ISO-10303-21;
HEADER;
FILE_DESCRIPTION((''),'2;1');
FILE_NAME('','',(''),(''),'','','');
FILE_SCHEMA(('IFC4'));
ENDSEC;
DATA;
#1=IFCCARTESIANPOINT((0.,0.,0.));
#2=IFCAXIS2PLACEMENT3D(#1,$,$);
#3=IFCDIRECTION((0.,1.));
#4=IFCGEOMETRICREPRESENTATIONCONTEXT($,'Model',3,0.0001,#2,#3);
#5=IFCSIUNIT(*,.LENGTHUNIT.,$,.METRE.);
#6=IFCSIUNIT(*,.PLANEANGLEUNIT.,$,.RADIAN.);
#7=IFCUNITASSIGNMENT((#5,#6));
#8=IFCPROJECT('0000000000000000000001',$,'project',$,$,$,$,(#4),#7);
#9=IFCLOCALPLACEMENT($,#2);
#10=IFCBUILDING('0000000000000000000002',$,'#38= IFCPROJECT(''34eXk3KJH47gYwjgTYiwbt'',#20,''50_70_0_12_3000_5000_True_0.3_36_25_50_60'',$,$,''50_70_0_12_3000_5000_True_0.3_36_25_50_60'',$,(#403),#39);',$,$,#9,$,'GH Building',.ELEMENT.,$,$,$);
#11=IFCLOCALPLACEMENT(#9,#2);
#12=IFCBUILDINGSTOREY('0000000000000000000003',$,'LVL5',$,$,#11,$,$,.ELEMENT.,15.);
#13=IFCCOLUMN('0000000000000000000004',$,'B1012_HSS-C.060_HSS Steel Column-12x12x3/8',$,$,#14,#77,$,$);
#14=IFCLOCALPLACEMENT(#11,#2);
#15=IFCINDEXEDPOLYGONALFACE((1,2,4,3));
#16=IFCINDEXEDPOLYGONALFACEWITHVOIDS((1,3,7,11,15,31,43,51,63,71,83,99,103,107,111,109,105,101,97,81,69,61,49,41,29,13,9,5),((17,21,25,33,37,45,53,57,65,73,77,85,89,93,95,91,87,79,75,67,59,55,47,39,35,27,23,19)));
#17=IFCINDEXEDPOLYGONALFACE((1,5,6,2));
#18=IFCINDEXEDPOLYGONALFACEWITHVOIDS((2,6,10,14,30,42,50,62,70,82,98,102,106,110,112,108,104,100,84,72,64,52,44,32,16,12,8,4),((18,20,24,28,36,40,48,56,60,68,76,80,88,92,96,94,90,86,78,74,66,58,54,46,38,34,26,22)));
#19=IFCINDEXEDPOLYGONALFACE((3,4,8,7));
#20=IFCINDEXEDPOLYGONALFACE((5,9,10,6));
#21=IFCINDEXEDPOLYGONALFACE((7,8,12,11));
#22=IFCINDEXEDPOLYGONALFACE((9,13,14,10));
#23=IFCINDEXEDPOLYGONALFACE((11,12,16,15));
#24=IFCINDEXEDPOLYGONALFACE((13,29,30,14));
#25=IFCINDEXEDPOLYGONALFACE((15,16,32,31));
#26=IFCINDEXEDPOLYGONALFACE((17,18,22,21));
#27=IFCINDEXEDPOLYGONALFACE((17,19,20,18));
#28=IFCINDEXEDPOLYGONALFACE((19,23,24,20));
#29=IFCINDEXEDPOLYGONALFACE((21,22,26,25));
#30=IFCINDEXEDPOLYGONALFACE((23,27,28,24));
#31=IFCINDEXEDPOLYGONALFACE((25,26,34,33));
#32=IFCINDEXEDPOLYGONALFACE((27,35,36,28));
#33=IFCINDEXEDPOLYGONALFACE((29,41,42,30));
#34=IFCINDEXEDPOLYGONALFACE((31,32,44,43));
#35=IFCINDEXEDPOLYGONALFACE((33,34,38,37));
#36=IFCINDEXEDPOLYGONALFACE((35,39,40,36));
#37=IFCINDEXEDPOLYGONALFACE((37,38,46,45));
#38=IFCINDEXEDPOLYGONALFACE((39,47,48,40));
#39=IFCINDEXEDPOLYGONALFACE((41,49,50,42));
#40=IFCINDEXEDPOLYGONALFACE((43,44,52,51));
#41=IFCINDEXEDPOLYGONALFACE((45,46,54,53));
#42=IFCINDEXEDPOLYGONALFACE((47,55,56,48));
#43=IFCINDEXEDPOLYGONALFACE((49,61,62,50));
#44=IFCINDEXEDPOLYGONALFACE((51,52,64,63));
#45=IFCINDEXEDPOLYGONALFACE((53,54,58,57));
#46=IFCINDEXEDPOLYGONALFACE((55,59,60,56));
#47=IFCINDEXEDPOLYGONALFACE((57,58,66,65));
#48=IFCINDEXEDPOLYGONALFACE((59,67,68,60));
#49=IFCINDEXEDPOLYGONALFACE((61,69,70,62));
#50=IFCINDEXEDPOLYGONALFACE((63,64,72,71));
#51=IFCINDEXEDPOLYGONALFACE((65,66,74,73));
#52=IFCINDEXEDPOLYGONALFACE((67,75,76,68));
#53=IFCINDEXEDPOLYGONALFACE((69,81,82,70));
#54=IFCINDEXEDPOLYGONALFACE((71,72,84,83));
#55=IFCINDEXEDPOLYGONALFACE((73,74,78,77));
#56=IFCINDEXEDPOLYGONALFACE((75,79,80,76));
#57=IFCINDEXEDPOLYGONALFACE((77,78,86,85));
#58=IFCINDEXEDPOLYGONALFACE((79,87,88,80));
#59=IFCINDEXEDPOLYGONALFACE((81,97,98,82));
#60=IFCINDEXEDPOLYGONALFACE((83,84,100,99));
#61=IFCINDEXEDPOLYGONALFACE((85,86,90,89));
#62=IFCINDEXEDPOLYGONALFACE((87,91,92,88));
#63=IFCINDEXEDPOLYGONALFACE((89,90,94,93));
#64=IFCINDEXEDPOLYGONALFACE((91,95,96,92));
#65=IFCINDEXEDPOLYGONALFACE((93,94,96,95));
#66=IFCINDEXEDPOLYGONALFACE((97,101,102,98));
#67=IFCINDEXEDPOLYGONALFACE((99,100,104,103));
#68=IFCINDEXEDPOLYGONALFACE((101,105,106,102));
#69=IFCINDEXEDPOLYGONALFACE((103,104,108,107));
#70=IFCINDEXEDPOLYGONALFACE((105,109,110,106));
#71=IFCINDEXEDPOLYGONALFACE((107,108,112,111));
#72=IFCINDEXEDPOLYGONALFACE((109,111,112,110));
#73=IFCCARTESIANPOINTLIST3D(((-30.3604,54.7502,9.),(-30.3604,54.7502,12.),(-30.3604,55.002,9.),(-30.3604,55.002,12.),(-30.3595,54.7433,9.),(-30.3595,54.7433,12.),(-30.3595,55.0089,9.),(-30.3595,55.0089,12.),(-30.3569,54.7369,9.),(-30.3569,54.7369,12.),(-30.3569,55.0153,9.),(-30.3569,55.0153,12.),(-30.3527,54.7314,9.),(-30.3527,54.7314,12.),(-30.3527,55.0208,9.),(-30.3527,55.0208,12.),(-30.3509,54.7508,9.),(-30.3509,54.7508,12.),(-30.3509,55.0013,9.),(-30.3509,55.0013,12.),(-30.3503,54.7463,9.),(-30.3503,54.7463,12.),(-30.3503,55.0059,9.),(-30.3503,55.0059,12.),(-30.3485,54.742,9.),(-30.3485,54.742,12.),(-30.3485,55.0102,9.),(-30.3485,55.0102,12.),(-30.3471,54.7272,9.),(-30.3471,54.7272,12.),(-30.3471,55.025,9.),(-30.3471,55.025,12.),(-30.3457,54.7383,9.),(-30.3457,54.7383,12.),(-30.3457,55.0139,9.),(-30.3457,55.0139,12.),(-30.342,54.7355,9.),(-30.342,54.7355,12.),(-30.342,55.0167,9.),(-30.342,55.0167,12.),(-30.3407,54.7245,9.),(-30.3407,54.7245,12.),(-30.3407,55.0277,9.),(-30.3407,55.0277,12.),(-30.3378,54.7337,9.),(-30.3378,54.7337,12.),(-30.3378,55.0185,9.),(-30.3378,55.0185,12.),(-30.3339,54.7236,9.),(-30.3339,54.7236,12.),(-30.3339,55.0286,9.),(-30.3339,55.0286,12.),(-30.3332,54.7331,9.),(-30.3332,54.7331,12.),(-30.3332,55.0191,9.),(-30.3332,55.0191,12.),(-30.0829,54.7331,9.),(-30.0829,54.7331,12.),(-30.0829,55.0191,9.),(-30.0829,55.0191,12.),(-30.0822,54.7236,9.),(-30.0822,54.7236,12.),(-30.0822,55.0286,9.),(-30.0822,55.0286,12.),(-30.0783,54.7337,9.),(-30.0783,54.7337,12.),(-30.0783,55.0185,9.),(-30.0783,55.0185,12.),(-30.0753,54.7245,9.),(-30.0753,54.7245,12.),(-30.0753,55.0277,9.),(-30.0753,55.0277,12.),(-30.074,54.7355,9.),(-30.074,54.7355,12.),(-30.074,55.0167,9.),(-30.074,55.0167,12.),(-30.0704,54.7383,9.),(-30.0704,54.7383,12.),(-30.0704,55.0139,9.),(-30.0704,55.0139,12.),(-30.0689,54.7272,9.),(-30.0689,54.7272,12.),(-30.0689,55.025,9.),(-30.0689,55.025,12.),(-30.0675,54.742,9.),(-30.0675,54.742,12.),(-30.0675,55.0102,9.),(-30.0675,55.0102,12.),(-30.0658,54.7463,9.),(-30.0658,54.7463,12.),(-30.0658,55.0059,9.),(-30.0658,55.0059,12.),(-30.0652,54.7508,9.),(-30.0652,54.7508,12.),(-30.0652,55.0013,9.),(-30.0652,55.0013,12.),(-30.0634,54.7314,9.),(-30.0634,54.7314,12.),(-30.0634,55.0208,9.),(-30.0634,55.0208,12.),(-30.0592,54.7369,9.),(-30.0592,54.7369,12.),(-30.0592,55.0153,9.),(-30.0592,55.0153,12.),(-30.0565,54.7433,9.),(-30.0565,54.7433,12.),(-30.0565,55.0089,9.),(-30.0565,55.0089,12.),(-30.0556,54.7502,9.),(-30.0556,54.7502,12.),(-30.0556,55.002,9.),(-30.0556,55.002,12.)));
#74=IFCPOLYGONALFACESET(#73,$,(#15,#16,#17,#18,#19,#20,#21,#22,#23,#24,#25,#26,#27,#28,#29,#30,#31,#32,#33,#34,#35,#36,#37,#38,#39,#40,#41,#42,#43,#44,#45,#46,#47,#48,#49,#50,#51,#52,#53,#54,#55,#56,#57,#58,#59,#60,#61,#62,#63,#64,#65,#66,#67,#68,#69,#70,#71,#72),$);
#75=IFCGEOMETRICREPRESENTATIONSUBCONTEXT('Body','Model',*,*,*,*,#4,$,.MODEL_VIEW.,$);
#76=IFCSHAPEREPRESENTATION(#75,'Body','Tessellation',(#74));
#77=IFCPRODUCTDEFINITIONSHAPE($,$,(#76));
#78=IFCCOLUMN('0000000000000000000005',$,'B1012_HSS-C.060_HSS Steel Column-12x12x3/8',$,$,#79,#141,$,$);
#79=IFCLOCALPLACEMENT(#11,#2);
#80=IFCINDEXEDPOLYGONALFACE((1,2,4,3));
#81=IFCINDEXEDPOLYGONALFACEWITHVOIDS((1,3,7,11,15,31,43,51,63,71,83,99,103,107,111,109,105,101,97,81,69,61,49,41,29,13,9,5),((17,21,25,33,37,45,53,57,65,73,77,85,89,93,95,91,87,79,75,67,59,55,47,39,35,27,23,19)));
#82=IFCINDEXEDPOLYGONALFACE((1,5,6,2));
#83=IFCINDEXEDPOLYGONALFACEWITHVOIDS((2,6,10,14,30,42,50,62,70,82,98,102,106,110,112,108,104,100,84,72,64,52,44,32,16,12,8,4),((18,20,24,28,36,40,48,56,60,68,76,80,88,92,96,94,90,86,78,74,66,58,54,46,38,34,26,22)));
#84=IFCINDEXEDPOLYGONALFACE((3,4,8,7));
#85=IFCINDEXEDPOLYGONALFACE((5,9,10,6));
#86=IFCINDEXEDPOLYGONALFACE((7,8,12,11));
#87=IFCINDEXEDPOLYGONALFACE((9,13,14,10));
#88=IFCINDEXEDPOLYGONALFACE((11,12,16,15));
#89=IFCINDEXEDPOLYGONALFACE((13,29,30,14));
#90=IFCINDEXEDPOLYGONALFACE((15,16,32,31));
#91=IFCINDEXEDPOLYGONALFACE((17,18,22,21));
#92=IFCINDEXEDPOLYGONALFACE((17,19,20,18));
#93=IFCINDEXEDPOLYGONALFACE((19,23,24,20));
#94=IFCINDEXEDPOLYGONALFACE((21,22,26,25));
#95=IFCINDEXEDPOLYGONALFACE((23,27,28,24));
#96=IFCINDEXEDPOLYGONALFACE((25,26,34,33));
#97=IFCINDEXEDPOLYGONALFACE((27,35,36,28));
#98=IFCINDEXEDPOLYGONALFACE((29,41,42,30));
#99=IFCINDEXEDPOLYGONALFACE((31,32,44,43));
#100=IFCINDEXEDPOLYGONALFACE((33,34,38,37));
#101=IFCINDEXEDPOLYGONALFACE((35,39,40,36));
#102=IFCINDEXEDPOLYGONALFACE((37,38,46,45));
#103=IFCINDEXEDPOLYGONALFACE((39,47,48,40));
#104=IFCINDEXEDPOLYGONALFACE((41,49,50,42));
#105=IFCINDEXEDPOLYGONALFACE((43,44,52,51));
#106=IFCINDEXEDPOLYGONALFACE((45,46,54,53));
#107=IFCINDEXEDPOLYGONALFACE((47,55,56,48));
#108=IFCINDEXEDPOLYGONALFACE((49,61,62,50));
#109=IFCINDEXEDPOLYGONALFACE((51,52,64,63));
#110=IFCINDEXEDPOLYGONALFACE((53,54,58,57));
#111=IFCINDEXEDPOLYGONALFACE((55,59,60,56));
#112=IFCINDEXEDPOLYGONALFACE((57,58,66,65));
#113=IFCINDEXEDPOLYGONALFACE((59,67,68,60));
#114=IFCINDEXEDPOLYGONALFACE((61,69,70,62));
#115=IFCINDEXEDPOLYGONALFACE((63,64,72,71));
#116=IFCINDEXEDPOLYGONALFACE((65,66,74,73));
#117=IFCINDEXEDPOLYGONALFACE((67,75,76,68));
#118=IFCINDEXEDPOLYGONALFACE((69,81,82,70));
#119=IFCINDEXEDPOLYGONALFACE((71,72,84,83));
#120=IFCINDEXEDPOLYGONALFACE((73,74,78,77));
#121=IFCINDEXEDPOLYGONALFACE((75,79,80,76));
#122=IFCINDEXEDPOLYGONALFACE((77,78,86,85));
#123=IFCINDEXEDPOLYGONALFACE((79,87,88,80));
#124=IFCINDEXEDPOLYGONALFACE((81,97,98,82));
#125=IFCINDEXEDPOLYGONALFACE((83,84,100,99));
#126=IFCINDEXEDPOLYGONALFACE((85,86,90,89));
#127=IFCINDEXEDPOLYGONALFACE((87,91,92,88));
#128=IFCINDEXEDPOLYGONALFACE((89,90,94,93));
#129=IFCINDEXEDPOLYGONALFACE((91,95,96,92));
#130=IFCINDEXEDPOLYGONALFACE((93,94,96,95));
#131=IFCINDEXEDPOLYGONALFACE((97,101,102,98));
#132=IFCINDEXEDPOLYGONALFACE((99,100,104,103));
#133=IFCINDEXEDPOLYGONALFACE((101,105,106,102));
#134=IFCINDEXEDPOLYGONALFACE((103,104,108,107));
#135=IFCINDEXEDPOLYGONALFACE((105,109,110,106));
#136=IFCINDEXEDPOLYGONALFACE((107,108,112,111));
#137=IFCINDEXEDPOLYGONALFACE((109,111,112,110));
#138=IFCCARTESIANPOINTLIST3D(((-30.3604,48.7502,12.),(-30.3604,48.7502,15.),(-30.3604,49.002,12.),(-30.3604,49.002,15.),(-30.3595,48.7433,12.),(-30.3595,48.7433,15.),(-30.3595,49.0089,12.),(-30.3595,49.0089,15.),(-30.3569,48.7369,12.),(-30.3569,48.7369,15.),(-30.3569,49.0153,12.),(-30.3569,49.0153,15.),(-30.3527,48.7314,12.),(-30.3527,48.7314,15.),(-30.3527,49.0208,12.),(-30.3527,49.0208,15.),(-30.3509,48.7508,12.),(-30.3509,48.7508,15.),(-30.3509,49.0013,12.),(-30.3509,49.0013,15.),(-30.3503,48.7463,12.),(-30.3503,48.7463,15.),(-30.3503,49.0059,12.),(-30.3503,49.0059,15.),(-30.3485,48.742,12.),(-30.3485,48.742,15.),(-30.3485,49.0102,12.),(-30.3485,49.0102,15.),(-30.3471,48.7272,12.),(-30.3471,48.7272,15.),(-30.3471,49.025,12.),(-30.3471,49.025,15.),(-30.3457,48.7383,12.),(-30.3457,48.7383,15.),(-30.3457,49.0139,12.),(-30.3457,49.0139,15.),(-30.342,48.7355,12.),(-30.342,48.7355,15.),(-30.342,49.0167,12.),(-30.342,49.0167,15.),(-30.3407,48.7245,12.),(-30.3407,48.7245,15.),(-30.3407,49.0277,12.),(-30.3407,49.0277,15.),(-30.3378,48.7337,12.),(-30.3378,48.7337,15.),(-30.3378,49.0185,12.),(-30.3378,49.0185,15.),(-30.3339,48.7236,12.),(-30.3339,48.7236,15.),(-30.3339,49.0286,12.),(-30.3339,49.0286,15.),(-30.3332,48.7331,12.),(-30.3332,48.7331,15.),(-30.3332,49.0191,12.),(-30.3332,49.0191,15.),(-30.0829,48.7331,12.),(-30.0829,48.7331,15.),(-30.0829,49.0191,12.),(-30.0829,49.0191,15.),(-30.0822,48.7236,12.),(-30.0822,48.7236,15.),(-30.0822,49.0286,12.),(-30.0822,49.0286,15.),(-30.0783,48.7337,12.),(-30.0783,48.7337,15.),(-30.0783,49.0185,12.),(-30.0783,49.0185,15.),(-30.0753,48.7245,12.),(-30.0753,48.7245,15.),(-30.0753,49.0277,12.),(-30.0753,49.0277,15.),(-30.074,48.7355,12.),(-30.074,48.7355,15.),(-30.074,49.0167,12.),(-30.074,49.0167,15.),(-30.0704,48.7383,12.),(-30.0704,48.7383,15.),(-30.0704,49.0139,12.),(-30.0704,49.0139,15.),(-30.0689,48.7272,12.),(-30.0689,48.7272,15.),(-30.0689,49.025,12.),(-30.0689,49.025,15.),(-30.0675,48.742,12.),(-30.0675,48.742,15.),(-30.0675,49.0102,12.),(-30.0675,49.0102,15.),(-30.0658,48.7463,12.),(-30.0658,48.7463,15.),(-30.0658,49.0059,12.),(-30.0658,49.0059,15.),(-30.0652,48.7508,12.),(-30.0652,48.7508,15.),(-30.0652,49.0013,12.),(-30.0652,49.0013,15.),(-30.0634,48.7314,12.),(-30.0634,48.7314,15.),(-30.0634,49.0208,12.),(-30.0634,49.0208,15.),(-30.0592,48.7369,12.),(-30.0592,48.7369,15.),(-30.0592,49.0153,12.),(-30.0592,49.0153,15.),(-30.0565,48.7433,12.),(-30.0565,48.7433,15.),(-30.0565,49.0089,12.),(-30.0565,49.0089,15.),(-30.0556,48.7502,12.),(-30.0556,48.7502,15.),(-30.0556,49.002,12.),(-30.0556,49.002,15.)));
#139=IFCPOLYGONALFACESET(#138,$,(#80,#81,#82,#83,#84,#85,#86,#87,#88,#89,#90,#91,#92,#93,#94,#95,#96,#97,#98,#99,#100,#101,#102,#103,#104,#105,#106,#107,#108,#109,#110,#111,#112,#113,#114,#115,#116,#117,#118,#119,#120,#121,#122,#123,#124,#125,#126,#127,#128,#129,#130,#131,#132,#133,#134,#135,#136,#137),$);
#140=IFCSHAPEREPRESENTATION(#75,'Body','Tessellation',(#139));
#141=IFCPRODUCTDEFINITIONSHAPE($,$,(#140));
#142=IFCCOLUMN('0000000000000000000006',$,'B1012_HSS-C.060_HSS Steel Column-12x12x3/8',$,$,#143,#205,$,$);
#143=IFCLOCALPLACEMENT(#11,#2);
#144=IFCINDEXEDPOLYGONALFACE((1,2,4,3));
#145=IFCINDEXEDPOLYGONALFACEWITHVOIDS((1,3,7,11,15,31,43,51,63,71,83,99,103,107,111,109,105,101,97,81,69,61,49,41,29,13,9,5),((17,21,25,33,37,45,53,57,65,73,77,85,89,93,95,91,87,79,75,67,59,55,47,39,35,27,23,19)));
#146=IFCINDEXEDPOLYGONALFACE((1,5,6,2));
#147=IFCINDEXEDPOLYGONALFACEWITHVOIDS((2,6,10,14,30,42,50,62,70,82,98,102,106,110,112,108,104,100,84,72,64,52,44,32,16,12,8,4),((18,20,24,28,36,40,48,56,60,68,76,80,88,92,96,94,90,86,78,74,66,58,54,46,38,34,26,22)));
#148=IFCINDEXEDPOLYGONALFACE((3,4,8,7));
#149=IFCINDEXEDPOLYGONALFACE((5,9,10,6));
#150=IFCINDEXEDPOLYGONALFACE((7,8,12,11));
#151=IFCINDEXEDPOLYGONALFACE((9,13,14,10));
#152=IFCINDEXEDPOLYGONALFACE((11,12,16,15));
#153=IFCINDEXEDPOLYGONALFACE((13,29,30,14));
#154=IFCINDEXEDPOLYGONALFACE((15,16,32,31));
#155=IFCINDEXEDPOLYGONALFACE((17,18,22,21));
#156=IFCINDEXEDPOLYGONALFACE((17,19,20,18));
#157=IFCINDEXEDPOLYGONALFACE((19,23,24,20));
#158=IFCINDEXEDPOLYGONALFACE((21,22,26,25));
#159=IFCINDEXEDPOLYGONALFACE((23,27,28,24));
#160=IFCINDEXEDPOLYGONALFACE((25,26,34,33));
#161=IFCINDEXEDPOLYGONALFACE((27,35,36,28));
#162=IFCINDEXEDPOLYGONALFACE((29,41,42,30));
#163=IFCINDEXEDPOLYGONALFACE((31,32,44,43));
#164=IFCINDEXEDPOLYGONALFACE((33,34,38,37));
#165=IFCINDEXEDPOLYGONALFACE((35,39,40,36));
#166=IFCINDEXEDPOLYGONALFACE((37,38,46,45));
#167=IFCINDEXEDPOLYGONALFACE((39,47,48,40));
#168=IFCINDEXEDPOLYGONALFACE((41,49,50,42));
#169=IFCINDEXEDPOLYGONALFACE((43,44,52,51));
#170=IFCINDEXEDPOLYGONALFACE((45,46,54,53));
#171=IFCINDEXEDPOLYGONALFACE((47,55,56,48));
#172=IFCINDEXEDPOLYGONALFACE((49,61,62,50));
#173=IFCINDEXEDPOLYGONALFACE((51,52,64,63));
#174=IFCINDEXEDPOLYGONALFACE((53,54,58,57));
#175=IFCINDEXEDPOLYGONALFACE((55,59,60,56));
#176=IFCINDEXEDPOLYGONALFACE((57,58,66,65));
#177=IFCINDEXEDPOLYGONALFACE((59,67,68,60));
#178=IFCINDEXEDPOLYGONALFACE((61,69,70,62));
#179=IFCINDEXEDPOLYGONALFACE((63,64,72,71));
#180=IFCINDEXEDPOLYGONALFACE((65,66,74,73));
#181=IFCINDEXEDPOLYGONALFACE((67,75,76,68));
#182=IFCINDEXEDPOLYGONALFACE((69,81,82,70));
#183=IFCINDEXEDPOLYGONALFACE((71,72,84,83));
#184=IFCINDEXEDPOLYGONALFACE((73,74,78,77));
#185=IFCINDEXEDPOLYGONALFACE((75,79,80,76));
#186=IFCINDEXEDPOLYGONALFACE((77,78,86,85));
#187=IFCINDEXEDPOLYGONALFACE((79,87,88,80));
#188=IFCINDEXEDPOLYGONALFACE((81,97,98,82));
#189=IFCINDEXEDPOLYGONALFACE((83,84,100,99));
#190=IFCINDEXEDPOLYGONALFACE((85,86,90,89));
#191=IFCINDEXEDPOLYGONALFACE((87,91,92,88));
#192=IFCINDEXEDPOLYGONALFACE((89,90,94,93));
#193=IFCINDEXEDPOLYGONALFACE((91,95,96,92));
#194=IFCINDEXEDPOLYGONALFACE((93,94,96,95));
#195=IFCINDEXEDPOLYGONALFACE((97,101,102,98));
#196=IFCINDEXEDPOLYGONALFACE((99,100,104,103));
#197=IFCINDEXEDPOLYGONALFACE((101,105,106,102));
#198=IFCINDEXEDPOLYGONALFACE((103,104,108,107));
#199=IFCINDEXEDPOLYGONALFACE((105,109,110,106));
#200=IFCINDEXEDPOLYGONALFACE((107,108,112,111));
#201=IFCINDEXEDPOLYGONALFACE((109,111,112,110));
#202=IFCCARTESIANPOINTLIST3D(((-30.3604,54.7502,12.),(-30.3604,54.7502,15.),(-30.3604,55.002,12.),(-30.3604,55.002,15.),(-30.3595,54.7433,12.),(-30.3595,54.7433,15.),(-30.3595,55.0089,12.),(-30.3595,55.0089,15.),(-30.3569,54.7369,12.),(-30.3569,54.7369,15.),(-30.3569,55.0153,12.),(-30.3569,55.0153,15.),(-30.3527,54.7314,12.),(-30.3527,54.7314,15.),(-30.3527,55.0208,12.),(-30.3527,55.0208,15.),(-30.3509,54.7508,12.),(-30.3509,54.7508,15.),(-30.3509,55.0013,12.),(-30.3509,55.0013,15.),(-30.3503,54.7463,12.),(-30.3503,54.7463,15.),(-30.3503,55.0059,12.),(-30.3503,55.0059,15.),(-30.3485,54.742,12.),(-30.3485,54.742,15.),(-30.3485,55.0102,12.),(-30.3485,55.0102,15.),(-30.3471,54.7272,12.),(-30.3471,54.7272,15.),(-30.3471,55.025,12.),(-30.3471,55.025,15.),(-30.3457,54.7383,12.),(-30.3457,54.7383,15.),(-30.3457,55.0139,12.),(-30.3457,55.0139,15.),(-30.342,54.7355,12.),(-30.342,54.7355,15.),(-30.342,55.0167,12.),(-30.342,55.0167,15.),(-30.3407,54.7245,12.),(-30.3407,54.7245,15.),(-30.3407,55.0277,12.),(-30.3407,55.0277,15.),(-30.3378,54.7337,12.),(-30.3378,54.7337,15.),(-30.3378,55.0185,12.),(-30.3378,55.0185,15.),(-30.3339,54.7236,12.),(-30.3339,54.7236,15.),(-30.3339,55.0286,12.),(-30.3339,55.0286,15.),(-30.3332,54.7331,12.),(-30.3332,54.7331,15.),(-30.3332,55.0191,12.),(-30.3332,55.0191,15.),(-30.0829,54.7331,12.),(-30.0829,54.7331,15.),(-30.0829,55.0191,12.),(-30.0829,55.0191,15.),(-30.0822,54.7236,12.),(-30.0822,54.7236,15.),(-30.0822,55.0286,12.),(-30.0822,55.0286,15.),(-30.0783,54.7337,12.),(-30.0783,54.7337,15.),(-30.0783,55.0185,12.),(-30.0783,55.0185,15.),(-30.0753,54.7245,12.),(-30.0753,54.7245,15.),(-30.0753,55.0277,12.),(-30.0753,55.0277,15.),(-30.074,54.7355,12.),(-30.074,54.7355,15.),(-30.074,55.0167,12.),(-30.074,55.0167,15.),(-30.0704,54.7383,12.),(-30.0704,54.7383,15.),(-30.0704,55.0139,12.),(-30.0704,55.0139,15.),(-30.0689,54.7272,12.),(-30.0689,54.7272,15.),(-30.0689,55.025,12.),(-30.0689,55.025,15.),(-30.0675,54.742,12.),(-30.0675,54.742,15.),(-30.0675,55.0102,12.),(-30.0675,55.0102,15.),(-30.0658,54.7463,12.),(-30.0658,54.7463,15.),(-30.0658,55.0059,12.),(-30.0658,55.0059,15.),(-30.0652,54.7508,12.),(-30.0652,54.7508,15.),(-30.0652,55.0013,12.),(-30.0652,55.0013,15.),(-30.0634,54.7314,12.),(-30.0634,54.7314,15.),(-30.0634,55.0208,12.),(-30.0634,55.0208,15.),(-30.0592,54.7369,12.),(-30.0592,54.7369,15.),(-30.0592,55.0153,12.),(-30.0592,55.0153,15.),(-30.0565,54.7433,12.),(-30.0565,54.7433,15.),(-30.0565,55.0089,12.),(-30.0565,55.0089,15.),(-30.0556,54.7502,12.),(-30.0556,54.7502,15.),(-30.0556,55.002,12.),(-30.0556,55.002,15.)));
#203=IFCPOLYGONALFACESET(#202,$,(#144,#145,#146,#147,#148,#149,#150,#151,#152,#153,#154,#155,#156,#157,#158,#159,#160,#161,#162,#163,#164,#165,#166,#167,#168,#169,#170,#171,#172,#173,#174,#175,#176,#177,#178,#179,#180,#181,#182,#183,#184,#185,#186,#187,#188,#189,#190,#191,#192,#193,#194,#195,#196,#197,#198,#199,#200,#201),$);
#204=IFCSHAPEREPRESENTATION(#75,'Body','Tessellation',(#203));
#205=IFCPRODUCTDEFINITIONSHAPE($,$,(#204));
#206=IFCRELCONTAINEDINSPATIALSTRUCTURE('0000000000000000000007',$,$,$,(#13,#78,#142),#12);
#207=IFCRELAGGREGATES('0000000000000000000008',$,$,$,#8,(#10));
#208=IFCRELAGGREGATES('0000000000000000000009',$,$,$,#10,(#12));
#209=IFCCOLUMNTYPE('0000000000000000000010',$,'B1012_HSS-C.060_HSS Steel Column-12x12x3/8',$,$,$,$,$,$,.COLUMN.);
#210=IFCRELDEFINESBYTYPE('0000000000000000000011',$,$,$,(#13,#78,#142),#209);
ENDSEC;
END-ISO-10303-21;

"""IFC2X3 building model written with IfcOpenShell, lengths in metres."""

from ifc_helpers import new_model, si_unit, direction, frame, origin, origin_2d, place, context, subcontext, project, spatial, hollow_rectangle, extrude, type_object, element, save


model = new_model("IFC2X3")

# Units and contexts
model_context = context("Model", 3, precision=0.0001, world=origin(), true_north=direction((0.0, 1.0)))
body_context = subcontext(model_context, "Body", "Model", "MODEL_VIEW")
ifc_project = project(units=[si_unit("LENGTHUNIT", "METRE"), si_unit("PLANEANGLEUNIT", "RADIAN")], contexts=[model_context])

# Building, storey
building_placement = place(None, origin())
building = spatial("IfcBuilding", under=ifc_project, at=building_placement, Name="#38= IFCPROJECT('34eXk3KJH47gYwjgTYiwbt',#20,'50_70_0_12_3000_5000_True_0.3_36_25_50_60',$,$,'50_70_0_12_3000_5000_True_0.3_36_25_50_60',$,(#403),#39);", LongName="GH Building", CompositionType="ELEMENT")
storey_placement = place(building_placement, origin())
storey = spatial("IfcBuildingStorey", under=building, at=storey_placement, Name="LVL5", CompositionType="ELEMENT", Elevation=15.0)

# Columns
column_type = type_object("IfcColumnType", Name="B1012_HSS-C.060_HSS Steel Column-12x12x3/8", PredefinedType="COLUMN")
for number, where, z_axis, x_axis, name in (
    (1, (-30.208, 54.8761, 12.0), (0.0, 0.0, -1.0), (-1.0, 0.0, 0.0), "B1012_HSS-C.060_HSS Steel Column-12x12x3/8"),
    (2, (-30.208, 48.8761, 15.0), (0.0, 0.0, -1.0), (-1.0, 0.0, 0.0), "B1012_HSS-C.060_HSS Steel Column-12x12x3/8"),
    (3, (-30.208, 54.8761, 15.0), (0.0, 0.0, -1.0), (-1.0, 0.0, 0.0), "B1012_HSS-C.060_HSS Steel Column-12x12x3/8"),
):
    element("IfcColumn", number, at=place(storey_placement, frame(where, z_axis=z_axis, x_axis=x_axis)), inside=storey, type_object=column_type, Name=name, context=body_context, shape_type="SweptSolid", body=[
        extrude(hollow_rectangle(XDim=0.3048, YDim=0.305, WallThickness=0.0095, InnerFilletRadius=0.0177, OuterFilletRadius=0.0266, at=origin_2d()), origin(), (0.0, 0.0, 1.0), 3.0),
    ])

save(model, "model.ifc")
